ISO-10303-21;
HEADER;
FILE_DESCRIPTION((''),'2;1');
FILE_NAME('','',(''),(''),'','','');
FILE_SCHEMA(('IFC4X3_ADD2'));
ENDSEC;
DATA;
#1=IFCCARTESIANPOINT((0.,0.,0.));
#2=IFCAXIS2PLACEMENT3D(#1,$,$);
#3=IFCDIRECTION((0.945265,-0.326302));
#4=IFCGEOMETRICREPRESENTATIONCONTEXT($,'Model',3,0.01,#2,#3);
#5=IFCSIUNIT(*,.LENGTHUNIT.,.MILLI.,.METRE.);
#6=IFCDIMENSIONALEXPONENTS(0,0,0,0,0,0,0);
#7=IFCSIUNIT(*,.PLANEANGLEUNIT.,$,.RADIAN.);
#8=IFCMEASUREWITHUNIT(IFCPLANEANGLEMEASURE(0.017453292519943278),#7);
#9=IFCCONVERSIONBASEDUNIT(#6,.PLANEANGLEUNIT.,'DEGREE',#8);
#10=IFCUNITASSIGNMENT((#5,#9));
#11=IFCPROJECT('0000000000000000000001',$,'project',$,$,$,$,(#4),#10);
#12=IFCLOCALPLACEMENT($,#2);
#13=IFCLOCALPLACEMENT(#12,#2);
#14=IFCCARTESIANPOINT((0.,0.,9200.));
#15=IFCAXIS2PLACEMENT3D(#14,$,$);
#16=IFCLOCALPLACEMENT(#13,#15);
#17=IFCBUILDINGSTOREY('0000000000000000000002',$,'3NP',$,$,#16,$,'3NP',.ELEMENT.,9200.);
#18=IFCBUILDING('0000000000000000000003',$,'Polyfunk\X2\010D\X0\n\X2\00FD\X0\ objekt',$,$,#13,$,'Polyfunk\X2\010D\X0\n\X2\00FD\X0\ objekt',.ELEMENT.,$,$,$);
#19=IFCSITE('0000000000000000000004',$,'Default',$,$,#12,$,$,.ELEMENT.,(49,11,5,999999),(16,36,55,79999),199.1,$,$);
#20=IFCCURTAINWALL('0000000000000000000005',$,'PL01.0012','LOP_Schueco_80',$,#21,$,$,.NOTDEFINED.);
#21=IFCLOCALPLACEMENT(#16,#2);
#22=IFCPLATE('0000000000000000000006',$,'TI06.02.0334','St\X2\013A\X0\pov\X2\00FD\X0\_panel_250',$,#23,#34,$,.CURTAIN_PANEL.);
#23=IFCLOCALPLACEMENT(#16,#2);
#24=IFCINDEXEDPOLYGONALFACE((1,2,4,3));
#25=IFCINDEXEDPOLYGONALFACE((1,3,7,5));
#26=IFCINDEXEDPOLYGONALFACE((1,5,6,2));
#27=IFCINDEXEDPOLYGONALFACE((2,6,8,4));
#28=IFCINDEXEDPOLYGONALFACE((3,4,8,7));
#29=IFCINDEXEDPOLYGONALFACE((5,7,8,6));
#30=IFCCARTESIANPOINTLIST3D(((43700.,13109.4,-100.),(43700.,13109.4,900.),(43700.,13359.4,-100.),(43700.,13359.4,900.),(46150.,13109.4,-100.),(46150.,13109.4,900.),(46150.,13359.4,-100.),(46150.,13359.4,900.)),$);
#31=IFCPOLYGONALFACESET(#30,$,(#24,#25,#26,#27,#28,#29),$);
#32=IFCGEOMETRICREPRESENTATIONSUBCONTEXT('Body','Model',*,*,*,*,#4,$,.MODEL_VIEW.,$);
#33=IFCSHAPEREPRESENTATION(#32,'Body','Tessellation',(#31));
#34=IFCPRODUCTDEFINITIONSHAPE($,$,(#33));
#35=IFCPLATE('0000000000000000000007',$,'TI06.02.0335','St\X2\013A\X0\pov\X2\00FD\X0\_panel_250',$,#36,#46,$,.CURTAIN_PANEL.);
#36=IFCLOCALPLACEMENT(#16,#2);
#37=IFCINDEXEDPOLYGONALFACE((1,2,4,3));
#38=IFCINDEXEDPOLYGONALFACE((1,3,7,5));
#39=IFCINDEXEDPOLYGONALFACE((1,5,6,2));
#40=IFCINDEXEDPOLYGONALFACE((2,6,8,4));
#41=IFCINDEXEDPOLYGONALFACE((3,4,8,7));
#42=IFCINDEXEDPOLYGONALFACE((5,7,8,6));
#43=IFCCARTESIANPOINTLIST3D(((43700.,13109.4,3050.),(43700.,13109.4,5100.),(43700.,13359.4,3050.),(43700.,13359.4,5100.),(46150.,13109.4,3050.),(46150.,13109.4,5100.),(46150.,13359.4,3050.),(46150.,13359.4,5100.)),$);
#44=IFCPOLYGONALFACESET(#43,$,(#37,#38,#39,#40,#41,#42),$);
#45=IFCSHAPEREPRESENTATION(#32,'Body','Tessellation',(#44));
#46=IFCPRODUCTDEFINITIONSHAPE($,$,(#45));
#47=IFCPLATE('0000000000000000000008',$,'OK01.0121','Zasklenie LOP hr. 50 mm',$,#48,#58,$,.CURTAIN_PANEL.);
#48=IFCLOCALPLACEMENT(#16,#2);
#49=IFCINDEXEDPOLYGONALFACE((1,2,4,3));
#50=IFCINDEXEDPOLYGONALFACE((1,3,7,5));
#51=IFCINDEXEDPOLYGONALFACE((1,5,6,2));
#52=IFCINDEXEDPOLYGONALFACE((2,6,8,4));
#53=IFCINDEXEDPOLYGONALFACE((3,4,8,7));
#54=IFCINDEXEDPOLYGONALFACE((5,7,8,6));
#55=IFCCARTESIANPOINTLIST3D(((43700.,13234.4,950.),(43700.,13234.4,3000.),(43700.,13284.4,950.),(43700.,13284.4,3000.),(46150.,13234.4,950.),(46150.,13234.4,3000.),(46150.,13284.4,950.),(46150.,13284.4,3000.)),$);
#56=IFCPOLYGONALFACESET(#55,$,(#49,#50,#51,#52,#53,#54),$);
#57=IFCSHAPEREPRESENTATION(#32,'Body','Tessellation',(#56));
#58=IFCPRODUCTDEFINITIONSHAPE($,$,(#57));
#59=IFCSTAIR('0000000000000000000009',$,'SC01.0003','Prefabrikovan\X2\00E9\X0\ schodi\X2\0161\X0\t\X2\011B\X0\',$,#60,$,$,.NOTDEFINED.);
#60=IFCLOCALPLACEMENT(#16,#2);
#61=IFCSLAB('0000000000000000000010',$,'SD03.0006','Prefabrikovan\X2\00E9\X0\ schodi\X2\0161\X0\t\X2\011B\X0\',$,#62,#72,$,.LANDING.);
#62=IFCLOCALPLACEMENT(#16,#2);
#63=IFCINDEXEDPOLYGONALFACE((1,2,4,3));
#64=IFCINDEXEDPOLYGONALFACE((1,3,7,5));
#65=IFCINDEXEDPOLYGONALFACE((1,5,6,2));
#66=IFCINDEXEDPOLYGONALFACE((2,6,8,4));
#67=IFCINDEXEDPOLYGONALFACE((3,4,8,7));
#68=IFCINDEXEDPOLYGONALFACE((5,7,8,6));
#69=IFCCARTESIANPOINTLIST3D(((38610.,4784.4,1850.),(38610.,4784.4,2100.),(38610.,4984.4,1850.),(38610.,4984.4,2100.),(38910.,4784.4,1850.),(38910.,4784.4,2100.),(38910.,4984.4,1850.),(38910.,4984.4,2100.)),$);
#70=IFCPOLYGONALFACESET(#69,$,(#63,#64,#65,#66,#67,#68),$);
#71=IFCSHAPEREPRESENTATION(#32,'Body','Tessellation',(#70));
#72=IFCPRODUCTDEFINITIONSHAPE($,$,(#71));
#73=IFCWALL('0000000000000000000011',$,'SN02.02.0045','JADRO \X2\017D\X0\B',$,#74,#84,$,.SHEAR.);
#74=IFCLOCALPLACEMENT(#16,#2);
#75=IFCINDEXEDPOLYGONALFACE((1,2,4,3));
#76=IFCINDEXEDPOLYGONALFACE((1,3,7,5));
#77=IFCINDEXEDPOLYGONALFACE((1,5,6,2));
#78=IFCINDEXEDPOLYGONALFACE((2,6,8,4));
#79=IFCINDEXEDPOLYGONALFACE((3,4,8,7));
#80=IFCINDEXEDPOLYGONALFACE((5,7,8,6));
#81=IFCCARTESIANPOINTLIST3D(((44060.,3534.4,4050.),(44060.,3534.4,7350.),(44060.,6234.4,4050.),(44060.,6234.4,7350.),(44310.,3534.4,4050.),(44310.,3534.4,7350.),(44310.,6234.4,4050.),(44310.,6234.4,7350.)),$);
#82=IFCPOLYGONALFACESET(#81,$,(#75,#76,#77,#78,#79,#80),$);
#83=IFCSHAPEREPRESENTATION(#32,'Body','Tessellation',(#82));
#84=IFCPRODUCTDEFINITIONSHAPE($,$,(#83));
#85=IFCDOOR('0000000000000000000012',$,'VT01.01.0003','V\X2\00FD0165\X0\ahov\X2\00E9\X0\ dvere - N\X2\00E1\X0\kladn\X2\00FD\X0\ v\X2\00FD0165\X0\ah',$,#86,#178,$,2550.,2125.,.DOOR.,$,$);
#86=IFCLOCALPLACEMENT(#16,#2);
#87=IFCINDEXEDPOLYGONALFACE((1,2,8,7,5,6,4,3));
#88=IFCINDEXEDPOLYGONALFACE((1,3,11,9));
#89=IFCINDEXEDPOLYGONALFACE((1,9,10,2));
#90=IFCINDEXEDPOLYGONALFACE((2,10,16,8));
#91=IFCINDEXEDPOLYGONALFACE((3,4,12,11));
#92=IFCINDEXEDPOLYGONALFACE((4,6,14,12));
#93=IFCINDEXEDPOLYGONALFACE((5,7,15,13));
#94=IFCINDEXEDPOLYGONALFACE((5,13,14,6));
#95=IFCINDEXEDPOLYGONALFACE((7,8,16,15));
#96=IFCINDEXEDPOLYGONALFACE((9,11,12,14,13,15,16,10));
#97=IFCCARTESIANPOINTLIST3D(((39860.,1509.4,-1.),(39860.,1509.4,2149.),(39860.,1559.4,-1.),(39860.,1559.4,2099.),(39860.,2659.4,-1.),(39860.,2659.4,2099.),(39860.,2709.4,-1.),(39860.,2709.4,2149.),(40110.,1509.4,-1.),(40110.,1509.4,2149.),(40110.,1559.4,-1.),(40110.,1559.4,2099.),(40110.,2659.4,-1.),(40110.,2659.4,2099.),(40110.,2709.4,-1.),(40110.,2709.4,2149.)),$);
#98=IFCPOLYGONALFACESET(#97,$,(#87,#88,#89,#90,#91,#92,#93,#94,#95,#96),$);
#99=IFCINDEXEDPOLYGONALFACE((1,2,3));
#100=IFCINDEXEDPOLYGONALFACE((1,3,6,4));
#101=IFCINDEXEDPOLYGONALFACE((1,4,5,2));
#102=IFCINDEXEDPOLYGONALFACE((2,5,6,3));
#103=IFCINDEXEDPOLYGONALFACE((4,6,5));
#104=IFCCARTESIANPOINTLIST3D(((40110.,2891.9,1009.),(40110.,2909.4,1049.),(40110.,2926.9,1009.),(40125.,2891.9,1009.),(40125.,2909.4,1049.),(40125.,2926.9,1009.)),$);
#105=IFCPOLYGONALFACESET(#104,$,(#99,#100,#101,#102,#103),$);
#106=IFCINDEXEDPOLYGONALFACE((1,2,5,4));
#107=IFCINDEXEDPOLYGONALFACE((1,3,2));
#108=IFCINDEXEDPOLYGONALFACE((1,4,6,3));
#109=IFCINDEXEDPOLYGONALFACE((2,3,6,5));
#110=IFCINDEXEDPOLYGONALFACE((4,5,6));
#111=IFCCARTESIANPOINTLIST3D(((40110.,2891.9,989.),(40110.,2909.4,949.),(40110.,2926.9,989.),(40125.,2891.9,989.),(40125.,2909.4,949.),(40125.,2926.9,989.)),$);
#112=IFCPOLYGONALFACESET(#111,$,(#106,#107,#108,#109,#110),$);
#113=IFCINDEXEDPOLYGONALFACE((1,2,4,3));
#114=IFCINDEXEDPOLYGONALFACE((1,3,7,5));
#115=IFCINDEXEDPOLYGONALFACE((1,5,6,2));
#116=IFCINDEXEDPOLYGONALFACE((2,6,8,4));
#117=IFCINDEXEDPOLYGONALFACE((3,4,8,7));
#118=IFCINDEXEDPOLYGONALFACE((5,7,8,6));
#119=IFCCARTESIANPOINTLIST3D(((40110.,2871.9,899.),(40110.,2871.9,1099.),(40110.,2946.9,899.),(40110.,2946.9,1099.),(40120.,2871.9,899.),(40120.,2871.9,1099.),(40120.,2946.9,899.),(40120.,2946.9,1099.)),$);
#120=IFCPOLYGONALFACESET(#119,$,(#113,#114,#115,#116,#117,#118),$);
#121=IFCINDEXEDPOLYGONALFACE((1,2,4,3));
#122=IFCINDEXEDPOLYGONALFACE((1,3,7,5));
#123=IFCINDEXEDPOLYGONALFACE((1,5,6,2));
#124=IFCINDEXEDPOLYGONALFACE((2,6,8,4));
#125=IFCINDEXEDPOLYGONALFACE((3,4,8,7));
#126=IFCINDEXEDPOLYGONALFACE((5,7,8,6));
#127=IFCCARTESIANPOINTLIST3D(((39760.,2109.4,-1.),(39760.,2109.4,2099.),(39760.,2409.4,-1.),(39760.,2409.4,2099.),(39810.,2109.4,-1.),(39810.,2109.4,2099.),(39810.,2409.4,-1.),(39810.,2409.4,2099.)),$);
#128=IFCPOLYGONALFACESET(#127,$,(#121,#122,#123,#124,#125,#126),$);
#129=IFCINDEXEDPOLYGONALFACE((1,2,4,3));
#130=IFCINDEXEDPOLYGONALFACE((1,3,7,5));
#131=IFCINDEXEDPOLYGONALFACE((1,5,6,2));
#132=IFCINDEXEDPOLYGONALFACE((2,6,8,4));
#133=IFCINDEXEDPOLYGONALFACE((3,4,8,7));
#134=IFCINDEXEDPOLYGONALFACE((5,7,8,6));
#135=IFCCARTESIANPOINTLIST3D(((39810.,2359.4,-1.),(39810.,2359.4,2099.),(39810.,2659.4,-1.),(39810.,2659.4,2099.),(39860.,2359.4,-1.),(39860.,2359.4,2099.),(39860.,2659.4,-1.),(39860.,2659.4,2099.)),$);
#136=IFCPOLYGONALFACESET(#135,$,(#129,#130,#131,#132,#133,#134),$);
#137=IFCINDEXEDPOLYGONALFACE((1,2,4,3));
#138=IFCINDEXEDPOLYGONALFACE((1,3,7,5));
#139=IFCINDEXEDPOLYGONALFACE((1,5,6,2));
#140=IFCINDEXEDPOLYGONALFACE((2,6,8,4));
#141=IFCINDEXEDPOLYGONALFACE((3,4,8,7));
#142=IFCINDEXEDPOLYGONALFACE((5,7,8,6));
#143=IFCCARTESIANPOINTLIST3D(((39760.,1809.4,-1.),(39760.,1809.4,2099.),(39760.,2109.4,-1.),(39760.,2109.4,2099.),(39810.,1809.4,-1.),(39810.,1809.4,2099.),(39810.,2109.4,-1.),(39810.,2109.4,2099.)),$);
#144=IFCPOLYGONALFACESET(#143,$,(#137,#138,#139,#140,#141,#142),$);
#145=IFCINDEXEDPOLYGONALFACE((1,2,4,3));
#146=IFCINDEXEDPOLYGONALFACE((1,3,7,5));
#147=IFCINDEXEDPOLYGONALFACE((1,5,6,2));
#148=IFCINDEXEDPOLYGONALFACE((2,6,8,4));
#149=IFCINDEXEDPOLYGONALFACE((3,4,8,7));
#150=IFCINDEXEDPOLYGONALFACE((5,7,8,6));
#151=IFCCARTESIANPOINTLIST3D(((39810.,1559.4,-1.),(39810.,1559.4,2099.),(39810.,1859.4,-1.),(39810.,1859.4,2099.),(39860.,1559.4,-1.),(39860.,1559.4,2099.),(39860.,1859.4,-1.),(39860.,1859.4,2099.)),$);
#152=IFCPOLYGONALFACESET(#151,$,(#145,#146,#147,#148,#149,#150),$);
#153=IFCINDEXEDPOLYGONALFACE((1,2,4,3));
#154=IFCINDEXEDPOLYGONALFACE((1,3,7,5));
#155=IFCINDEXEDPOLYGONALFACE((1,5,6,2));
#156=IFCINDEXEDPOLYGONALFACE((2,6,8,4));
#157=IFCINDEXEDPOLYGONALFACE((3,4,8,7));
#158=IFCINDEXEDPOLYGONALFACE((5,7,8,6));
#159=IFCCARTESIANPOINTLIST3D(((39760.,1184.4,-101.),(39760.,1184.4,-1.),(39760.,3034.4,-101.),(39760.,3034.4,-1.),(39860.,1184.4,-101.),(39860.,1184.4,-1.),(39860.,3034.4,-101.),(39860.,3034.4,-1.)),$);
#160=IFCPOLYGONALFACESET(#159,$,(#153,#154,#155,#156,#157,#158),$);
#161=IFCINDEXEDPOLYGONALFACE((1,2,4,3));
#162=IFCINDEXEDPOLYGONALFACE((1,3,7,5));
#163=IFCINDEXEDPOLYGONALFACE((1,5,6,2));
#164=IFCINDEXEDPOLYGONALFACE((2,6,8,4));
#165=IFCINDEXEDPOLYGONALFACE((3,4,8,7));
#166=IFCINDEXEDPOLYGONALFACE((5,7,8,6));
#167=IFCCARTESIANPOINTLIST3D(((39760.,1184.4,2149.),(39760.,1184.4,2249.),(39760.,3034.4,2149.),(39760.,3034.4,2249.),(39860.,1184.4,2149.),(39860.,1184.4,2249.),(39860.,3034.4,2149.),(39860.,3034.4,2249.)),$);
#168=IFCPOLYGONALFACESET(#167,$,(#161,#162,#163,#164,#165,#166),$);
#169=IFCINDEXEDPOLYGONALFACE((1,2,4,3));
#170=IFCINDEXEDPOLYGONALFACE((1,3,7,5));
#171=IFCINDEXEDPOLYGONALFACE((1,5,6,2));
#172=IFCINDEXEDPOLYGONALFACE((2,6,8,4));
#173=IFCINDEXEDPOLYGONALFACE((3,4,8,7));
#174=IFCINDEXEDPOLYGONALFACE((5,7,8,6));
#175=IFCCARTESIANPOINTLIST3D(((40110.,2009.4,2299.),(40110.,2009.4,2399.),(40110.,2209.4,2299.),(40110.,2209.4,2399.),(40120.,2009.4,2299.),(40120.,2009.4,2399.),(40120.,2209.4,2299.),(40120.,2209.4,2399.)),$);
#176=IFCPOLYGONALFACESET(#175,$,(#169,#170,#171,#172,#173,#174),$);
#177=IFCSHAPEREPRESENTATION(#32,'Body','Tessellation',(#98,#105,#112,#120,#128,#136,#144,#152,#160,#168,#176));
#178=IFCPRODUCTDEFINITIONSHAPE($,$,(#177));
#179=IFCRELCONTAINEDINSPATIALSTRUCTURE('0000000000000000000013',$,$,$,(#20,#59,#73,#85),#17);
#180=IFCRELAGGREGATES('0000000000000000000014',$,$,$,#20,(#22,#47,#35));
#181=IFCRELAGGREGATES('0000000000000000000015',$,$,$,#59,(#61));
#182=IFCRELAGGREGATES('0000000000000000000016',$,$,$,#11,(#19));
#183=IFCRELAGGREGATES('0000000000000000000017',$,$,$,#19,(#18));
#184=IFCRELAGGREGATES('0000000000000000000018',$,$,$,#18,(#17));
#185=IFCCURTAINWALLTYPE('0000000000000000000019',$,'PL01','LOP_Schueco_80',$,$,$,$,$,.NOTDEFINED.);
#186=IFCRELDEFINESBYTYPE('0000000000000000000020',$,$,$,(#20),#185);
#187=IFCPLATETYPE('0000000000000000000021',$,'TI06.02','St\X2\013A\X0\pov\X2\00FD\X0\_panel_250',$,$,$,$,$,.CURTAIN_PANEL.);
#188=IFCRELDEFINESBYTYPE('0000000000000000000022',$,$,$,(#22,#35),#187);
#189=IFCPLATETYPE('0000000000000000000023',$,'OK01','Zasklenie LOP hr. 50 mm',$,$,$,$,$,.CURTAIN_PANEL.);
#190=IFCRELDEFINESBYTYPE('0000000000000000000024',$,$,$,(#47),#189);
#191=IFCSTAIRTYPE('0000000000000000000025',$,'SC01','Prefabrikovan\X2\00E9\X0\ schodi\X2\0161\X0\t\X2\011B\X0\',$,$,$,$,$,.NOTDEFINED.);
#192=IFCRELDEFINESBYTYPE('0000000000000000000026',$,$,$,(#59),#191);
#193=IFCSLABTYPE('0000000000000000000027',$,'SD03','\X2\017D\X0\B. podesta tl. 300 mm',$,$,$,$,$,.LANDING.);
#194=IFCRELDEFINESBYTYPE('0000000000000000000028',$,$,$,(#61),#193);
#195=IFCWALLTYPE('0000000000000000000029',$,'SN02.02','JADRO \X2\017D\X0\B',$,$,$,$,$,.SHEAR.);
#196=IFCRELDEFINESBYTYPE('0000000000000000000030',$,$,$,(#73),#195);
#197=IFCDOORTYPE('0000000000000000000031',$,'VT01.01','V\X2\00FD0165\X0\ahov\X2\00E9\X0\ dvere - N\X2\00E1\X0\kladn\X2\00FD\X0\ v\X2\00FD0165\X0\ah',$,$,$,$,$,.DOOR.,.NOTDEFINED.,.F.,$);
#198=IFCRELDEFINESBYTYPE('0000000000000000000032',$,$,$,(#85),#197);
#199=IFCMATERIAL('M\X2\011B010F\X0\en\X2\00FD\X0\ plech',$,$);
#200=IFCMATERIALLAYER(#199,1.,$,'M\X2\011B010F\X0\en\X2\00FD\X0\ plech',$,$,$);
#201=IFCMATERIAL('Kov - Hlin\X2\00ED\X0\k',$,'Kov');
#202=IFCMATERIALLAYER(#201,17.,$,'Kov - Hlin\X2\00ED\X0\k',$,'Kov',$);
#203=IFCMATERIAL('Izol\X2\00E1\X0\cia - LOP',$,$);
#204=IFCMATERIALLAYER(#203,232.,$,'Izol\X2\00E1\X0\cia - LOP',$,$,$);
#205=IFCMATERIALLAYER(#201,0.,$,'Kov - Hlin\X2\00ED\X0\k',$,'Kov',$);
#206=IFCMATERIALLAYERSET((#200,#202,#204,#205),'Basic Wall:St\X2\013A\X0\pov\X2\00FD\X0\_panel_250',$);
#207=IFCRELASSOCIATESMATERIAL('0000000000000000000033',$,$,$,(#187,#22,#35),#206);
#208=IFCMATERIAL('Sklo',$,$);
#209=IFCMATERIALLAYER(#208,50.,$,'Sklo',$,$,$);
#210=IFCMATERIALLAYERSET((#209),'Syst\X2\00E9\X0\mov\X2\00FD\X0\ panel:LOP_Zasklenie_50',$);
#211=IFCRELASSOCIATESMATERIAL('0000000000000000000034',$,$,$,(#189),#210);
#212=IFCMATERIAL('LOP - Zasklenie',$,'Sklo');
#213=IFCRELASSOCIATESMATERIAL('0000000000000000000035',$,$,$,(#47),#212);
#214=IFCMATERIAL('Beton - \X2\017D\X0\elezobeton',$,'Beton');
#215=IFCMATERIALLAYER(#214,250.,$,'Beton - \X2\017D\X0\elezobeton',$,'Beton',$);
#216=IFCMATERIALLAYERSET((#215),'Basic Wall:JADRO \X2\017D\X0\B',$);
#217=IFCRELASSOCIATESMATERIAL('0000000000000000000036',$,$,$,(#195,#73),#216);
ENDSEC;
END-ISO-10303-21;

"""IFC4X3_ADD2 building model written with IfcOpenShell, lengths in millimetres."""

from ifc_helpers import new_model, entity, si_unit, converted_unit, direction, frame, frame_2d, origin, origin_2d_with_axis, place, context, subcontext, project, spatial, polyline, rectangle, outline, extrude, clip, bounded_halfspace, source, transform, mapped, material, layer, layer_set, layer_usage, type_object, type_shapes, element, aggregate, save


model = new_model("IFC4X3_ADD2")

# Units and contexts
model_context = context("Model", 3, precision=0.01, world=origin(), true_north=direction((0.945265, -0.326302)))
body_context = subcontext(model_context, "Body", "Model", "MODEL_VIEW")
ifc_project = project(units=[si_unit("LENGTHUNIT", "METRE", prefix="MILLI"), converted_unit("PLANEANGLEUNIT", "DEGREE", entity("IfcPlaneAngleMeasure", 0.017453292519943278), si_unit("PLANEANGLEUNIT", "RADIAN"), dimensions=[0, 0, 0, 0, 0, 0, 0])], contexts=[model_context])

# Site, building, storey
site_placement = place(None, origin())
site = spatial("IfcSite", under=ifc_project, at=site_placement, Name="Default", CompositionType="ELEMENT", RefLatitude=(49, 11, 5, 999999), RefLongitude=(16, 36, 55, 79999), RefElevation=199.1)
building_placement = place(site_placement, origin())
building = spatial("IfcBuilding", under=site, at=building_placement, Name="Polyfunkčný objekt", LongName="Polyfunkčný objekt", CompositionType="ELEMENT")
storey_placement = place(building_placement, frame((0.0, 0.0, 9200.0)))
storey = spatial("IfcBuildingStorey", under=building, at=storey_placement, Name="3NP", LongName="3NP", CompositionType="ELEMENT", Elevation=9200.0)

# Curtain wall, plates
curtain_wall_type = type_object("IfcCurtainWallType", Name="PL01", Description="LOP_Schueco_80", PredefinedType="NOTDEFINED")
curtain_wall_placement = place(storey_placement, frame((0.0, 0.0, -9200.0)))
curtain_wall = element("IfcCurtainWall", 1, at=curtain_wall_placement, inside=storey, type_object=curtain_wall_type, Name="PL01.0012", Description="LOP_Schueco_80", PredefinedType="NOTDEFINED")
ifc_material_1 = material(Name="Měďený plech")
ifc_layer_1 = layer(ifc_material_1, 1.0, Name="Měďený plech")
ifc_material_2 = material(Name="Kov - Hliník", Category="Kov")
ifc_layer_2 = layer(ifc_material_2, 17.0, Name="Kov - Hliník", Category="Kov")
ifc_material_3 = material(Name="Izolácia - LOP")
ifc_layer_3 = layer(ifc_material_3, 232.0, Name="Izolácia - LOP")
ifc_layer_4 = layer(ifc_material_2, 0.0, Name="Kov - Hliník", Category="Kov")
ifc_layer_set_1 = layer_set([ifc_layer_1, ifc_layer_2, ifc_layer_3, ifc_layer_4], Name="Basic Wall:Stĺpový_panel_250")
ifc_layer_usage_1 = layer_usage(ifc_layer_set_1, "AXIS2", "NEGATIVE", 125.0)
plate_type_1 = type_object("IfcPlateType", Name="TI06.02", Description="Stĺpový_panel_250", PredefinedType="CURTAIN_PANEL", material=ifc_layer_set_1)
plate_1_placement = place(storey_placement, frame((43700.0, 13234.4, -100.0)))
plate_1 = element("IfcPlate", 2, at=plate_1_placement, type_object=plate_type_1, material=ifc_layer_usage_1, Name="TI06.02.0334", Description="Stĺpový_panel_250", PredefinedType="CURTAIN_PANEL", context=body_context, shape_type="SweptSolid", body=[
    extrude(rectangle(XDim=250.0, YDim=2450.0, at=frame_2d((0.0, 0.0), x_axis=(1.0, 0.0))), frame((1225.0, 0.0, 0.0), z_axis=(0.0, 0.0, 1.0), x_axis=(0.0, 1.0, 0.0)), (0.0, 0.0, 1.0), 1000.0),
])
ifc_layer_usage_2 = layer_usage(ifc_layer_set_1, "AXIS2", "NEGATIVE", 125.0)
plate_2_placement = place(storey_placement, frame((43700.0, 13234.4, 3050.0)))
plate_2 = element("IfcPlate", 3, at=plate_2_placement, type_object=plate_type_1, material=ifc_layer_usage_2, Name="TI06.02.0335", Description="Stĺpový_panel_250", PredefinedType="CURTAIN_PANEL", context=body_context, shape_type="SweptSolid", body=[
    extrude(rectangle(XDim=250.0, YDim=2450.0, at=frame_2d((0.0, 0.0), x_axis=(1.0, 0.0))), frame((1225.0, 0.0, 0.0), z_axis=(0.0, 0.0, 1.0), x_axis=(0.0, 1.0, 0.0)), (0.0, 0.0, 1.0), 2050.0),
])
ifc_material_4 = material(Name="LOP - Zasklenie", Category="Sklo")
ifc_material_5 = material(Name="Sklo")
ifc_layer_5 = layer(ifc_material_5, 50.0, Name="Sklo")
ifc_layer_set_2 = layer_set([ifc_layer_5], Name="Systémový panel:LOP_Zasklenie_50")
plate_type_2 = type_object("IfcPlateType", Name="OK01", Description="Zasklenie LOP hr. 50 mm", PredefinedType="CURTAIN_PANEL", material=ifc_layer_set_2)
shared_shape_1 = source(origin(), body_context, "Body", "SweptSolid", [
    extrude(rectangle(XDim=50.0, YDim=2450.0, at=origin_2d_with_axis()), frame((0.0, 25.0, 0.0), z_axis=(0.0, 0.0, 1.0), x_axis=(0.0, 1.0, 0.0)), (0.0, 0.0, 1.0), 2050.0),
])
type_shapes(plate_type_2, [shared_shape_1])
plate_3_placement = place(curtain_wall_placement, frame((44925.0, 13234.4, 10150.0)))
plate_3 = element("IfcPlate", 4, at=plate_3_placement, type_object=plate_type_2, material=ifc_material_4, Name="OK01.0121", Description="Zasklenie LOP hr. 50 mm", PredefinedType="CURTAIN_PANEL", context=body_context, shape_type="MappedRepresentation", body=[
    mapped(shared_shape_1, transform((0.0, 0.0, 0.0), scale=1.0)),
])
aggregate(curtain_wall, [plate_1, plate_3, plate_2])

# Stair, slab
stair_type = type_object("IfcStairType", Name="SC01", Description="Prefabrikované schodiště", PredefinedType="NOTDEFINED")
stair_placement = place(storey_placement, origin())
stair = element("IfcStair", 5, at=stair_placement, inside=storey, type_object=stair_type, Name="SC01.0003", Description="Prefabrikované schodiště", PredefinedType="NOTDEFINED")
slab_type = type_object("IfcSlabType", Name="SD03", Description="ŽB. podesta tl. 300 mm", PredefinedType="LANDING")
slab_placement = place(stair_placement, frame((38610.0, 4784.4, 0.0)))
slab = element("IfcSlab", 6, at=slab_placement, type_object=slab_type, Name="SD03.0006", Description="Prefabrikované schodiště", PredefinedType="LANDING", context=body_context, shape_type="SweptSolid", body=[
    extrude(rectangle(XDim=200.0, YDim=300.0, at=frame_2d((0.0, 0.0), x_axis=(1.0, 0.0))), frame((150.0, 100.0, 1850.0), z_axis=(0.0, 0.0, 1.0), x_axis=(0.0, 1.0, 0.0)), (0.0, 0.0, 1.0), 250.0),
])
aggregate(stair, [slab])

# Wall
ifc_material_6 = material(Name="Beton - Železobeton", Category="Beton")
ifc_layer_6 = layer(ifc_material_6, 250.0, Name="Beton - Železobeton", Category="Beton")
ifc_layer_set_3 = layer_set([ifc_layer_6], Name="Basic Wall:JADRO ŽB")
wall_type = type_object("IfcWallType", Name="SN02.02", Description="JADRO ŽB", PredefinedType="SHEAR", material=ifc_layer_set_3)
wall_placement = place(storey_placement, frame((44185.0, 6234.4, 4050.0), z_axis=(0.0, 0.0, 1.0), x_axis=(0.0, -1.0, 0.0)))
element("IfcWall", 7, at=wall_placement, inside=storey, type_object=wall_type, material=ifc_layer_set_3, Name="SN02.02.0045", Description="JADRO ŽB", PredefinedType="SHEAR", context=body_context, shape_type="Clipping", body=[
    clip(clip(extrude(rectangle(XDim=2700.0, YDim=250.0, at=frame_2d((1350.0, 0.0), x_axis=(-1.0, 0.0))), origin(), (0.0, 0.0, 1.0), 3300.0), bounded_halfspace(frame((2700.0, -125.0, 0.0), z_axis=(0.0, 0.0, 1.0), x_axis=(0.0, -1.0, 0.0)), True, frame((2700.0, -125.0, 0.0)), polyline([(0.0, 0.0), (0.0, 250.0), (-2700.0, 250.0), (-2700.0, 0.0), (0.0, 0.0)]))), bounded_halfspace(frame((0.0, -125.0, 3300.0), z_axis=(0.0, 0.0, -1.0), x_axis=(1.0, 0.0, 0.0)), True, frame((0.0, -125.0, 3300.0)), polyline([(0.0, 0.0), (2700.0, 0.0), (2700.0, 250.0), (0.0, 250.0), (0.0, 0.0)]))),
])

# Door
door_type_1 = type_object("IfcDoorType", Name="VT01.01", Description="Výťahové dvere - Nákladný výťah", OperationType="NOTDEFINED", ParameterTakesPrecedence=False, PredefinedType="DOOR")
shared_shape_2 = source(origin(), body_context, "Body", "SweptSolid", [
    extrude(outline(polyline([(-1087.5, -600.0), (1062.5, -600.0), (1062.5, -550.0), (-1037.5, -550.0), (-1037.5, 550.0), (1062.5, 550.0), (1062.5, 600.0), (-1087.5, 600.0), (-1087.5, -600.0)])), frame((600.0, 0.0, 1062.5), z_axis=(0.0, 1.0, 0.0), x_axis=(0.0, 0.0, -1.0)), (0.0, 0.0, 1.0), 250.0),
    extrude(outline(polyline([(-24.4, -10.7), (19.2, -10.7), (5.2, 21.4), (-24.4, -10.7)])), frame((1400.0, -15.0, 1023.3), z_axis=(0.0, 1.0, 0.0), x_axis=(0.400819, 0.0, -0.916157)), (0.0, 0.0, 1.0), 15.0),
    extrude(outline(polyline([(-24.4, -10.7), (19.2, -10.7), (5.2, 21.4), (-24.4, -10.7)])), frame((1400.0, -15.0, 976.7), z_axis=(0.0, 1.0, 0.0), x_axis=(-0.400819, 0.0, 0.916157)), (0.0, 0.0, 1.0), 15.0),
    extrude(rectangle(XDim=10.0, YDim=75.0, at=frame_2d((0.0, 0.0), x_axis=(1.0, 0.0))), frame((1400.0, -5.0, 900.0), z_axis=(0.0, 0.0, 1.0), x_axis=(0.0, 1.0, 0.0)), (0.0, 0.0, 1.0), 200.0),
    extrude(rectangle(XDim=50.0, YDim=300.0, at=origin_2d_with_axis()), frame((750.0, 325.0, 0.0), z_axis=(0.0, 0.0, 1.0), x_axis=(0.0, -1.0, 0.0)), (0.0, 0.0, 1.0), 2100.0),
    extrude(rectangle(XDim=50.0, YDim=300.0, at=frame_2d((0.0, 0.0), x_axis=(1.0, 0.0))), frame((1000.0, 275.0, 0.0), z_axis=(0.0, 0.0, 1.0), x_axis=(0.0, -1.0, 0.0)), (0.0, 0.0, 1.0), 2100.0),
    extrude(rectangle(XDim=300.0, YDim=50.0, at=frame_2d((0.0, 0.0), x_axis=(1.0, 0.0))), frame((450.0, 325.0, 0.0), z_axis=(0.0, 0.0, 1.0), x_axis=(-1.0, 0.0, 0.0)), (0.0, 0.0, 1.0), 2100.0),
    extrude(rectangle(XDim=300.0, YDim=50.0, at=frame_2d((0.0, 0.0), x_axis=(1.0, 0.0))), frame((200.0, 275.0, 0.0), z_axis=(0.0, 0.0, 1.0), x_axis=(-1.0, 0.0, 0.0)), (0.0, 0.0, 1.0), 2100.0),
    extrude(rectangle(XDim=1850.0, YDim=100.0, at=frame_2d((0.0, 0.0), x_axis=(1.0, 0.0))), frame((600.0, 300.0, -100.0), z_axis=(0.0, 0.0, 1.0), x_axis=(-1.0, 0.0, 0.0)), (0.0, 0.0, 1.0), 100.0),
    extrude(rectangle(XDim=1850.0, YDim=100.0, at=frame_2d((0.0, 0.0), x_axis=(1.0, 0.0))), frame((600.0, 300.0, 2150.0), z_axis=(0.0, 0.0, 1.0), x_axis=(-1.0, 0.0, 0.0)), (0.0, 0.0, 1.0), 100.0),
    extrude(rectangle(XDim=10.0, YDim=200.0, at=frame_2d((0.0, 0.0), x_axis=(1.0, 0.0))), frame((600.0, -5.0, 2300.0), z_axis=(0.0, 0.0, 1.0), x_axis=(0.0, 1.0, 0.0)), (0.0, 0.0, 1.0), 100.0),
])
type_shapes(door_type_1, [shared_shape_2])
door_1_placement = place(storey_placement, frame((40110.0, 1509.4, -1.0), z_axis=(0.0, 0.0, 1.0), x_axis=(0.0, 1.0, 0.0)))
element("IfcDoor", 8, at=door_1_placement, inside=storey, type_object=door_type_1, Name="VT01.01.0003", Description="Výťahové dvere - Nákladný výťah", OverallHeight=2550.0, OverallWidth=2125.0, PredefinedType="DOOR", context=body_context, shape_type="MappedRepresentation", body=[
    mapped(shared_shape_2, transform((0.0, 0.0, 0.0), scale=1.0)),
])

save(model, "model.ifc")
